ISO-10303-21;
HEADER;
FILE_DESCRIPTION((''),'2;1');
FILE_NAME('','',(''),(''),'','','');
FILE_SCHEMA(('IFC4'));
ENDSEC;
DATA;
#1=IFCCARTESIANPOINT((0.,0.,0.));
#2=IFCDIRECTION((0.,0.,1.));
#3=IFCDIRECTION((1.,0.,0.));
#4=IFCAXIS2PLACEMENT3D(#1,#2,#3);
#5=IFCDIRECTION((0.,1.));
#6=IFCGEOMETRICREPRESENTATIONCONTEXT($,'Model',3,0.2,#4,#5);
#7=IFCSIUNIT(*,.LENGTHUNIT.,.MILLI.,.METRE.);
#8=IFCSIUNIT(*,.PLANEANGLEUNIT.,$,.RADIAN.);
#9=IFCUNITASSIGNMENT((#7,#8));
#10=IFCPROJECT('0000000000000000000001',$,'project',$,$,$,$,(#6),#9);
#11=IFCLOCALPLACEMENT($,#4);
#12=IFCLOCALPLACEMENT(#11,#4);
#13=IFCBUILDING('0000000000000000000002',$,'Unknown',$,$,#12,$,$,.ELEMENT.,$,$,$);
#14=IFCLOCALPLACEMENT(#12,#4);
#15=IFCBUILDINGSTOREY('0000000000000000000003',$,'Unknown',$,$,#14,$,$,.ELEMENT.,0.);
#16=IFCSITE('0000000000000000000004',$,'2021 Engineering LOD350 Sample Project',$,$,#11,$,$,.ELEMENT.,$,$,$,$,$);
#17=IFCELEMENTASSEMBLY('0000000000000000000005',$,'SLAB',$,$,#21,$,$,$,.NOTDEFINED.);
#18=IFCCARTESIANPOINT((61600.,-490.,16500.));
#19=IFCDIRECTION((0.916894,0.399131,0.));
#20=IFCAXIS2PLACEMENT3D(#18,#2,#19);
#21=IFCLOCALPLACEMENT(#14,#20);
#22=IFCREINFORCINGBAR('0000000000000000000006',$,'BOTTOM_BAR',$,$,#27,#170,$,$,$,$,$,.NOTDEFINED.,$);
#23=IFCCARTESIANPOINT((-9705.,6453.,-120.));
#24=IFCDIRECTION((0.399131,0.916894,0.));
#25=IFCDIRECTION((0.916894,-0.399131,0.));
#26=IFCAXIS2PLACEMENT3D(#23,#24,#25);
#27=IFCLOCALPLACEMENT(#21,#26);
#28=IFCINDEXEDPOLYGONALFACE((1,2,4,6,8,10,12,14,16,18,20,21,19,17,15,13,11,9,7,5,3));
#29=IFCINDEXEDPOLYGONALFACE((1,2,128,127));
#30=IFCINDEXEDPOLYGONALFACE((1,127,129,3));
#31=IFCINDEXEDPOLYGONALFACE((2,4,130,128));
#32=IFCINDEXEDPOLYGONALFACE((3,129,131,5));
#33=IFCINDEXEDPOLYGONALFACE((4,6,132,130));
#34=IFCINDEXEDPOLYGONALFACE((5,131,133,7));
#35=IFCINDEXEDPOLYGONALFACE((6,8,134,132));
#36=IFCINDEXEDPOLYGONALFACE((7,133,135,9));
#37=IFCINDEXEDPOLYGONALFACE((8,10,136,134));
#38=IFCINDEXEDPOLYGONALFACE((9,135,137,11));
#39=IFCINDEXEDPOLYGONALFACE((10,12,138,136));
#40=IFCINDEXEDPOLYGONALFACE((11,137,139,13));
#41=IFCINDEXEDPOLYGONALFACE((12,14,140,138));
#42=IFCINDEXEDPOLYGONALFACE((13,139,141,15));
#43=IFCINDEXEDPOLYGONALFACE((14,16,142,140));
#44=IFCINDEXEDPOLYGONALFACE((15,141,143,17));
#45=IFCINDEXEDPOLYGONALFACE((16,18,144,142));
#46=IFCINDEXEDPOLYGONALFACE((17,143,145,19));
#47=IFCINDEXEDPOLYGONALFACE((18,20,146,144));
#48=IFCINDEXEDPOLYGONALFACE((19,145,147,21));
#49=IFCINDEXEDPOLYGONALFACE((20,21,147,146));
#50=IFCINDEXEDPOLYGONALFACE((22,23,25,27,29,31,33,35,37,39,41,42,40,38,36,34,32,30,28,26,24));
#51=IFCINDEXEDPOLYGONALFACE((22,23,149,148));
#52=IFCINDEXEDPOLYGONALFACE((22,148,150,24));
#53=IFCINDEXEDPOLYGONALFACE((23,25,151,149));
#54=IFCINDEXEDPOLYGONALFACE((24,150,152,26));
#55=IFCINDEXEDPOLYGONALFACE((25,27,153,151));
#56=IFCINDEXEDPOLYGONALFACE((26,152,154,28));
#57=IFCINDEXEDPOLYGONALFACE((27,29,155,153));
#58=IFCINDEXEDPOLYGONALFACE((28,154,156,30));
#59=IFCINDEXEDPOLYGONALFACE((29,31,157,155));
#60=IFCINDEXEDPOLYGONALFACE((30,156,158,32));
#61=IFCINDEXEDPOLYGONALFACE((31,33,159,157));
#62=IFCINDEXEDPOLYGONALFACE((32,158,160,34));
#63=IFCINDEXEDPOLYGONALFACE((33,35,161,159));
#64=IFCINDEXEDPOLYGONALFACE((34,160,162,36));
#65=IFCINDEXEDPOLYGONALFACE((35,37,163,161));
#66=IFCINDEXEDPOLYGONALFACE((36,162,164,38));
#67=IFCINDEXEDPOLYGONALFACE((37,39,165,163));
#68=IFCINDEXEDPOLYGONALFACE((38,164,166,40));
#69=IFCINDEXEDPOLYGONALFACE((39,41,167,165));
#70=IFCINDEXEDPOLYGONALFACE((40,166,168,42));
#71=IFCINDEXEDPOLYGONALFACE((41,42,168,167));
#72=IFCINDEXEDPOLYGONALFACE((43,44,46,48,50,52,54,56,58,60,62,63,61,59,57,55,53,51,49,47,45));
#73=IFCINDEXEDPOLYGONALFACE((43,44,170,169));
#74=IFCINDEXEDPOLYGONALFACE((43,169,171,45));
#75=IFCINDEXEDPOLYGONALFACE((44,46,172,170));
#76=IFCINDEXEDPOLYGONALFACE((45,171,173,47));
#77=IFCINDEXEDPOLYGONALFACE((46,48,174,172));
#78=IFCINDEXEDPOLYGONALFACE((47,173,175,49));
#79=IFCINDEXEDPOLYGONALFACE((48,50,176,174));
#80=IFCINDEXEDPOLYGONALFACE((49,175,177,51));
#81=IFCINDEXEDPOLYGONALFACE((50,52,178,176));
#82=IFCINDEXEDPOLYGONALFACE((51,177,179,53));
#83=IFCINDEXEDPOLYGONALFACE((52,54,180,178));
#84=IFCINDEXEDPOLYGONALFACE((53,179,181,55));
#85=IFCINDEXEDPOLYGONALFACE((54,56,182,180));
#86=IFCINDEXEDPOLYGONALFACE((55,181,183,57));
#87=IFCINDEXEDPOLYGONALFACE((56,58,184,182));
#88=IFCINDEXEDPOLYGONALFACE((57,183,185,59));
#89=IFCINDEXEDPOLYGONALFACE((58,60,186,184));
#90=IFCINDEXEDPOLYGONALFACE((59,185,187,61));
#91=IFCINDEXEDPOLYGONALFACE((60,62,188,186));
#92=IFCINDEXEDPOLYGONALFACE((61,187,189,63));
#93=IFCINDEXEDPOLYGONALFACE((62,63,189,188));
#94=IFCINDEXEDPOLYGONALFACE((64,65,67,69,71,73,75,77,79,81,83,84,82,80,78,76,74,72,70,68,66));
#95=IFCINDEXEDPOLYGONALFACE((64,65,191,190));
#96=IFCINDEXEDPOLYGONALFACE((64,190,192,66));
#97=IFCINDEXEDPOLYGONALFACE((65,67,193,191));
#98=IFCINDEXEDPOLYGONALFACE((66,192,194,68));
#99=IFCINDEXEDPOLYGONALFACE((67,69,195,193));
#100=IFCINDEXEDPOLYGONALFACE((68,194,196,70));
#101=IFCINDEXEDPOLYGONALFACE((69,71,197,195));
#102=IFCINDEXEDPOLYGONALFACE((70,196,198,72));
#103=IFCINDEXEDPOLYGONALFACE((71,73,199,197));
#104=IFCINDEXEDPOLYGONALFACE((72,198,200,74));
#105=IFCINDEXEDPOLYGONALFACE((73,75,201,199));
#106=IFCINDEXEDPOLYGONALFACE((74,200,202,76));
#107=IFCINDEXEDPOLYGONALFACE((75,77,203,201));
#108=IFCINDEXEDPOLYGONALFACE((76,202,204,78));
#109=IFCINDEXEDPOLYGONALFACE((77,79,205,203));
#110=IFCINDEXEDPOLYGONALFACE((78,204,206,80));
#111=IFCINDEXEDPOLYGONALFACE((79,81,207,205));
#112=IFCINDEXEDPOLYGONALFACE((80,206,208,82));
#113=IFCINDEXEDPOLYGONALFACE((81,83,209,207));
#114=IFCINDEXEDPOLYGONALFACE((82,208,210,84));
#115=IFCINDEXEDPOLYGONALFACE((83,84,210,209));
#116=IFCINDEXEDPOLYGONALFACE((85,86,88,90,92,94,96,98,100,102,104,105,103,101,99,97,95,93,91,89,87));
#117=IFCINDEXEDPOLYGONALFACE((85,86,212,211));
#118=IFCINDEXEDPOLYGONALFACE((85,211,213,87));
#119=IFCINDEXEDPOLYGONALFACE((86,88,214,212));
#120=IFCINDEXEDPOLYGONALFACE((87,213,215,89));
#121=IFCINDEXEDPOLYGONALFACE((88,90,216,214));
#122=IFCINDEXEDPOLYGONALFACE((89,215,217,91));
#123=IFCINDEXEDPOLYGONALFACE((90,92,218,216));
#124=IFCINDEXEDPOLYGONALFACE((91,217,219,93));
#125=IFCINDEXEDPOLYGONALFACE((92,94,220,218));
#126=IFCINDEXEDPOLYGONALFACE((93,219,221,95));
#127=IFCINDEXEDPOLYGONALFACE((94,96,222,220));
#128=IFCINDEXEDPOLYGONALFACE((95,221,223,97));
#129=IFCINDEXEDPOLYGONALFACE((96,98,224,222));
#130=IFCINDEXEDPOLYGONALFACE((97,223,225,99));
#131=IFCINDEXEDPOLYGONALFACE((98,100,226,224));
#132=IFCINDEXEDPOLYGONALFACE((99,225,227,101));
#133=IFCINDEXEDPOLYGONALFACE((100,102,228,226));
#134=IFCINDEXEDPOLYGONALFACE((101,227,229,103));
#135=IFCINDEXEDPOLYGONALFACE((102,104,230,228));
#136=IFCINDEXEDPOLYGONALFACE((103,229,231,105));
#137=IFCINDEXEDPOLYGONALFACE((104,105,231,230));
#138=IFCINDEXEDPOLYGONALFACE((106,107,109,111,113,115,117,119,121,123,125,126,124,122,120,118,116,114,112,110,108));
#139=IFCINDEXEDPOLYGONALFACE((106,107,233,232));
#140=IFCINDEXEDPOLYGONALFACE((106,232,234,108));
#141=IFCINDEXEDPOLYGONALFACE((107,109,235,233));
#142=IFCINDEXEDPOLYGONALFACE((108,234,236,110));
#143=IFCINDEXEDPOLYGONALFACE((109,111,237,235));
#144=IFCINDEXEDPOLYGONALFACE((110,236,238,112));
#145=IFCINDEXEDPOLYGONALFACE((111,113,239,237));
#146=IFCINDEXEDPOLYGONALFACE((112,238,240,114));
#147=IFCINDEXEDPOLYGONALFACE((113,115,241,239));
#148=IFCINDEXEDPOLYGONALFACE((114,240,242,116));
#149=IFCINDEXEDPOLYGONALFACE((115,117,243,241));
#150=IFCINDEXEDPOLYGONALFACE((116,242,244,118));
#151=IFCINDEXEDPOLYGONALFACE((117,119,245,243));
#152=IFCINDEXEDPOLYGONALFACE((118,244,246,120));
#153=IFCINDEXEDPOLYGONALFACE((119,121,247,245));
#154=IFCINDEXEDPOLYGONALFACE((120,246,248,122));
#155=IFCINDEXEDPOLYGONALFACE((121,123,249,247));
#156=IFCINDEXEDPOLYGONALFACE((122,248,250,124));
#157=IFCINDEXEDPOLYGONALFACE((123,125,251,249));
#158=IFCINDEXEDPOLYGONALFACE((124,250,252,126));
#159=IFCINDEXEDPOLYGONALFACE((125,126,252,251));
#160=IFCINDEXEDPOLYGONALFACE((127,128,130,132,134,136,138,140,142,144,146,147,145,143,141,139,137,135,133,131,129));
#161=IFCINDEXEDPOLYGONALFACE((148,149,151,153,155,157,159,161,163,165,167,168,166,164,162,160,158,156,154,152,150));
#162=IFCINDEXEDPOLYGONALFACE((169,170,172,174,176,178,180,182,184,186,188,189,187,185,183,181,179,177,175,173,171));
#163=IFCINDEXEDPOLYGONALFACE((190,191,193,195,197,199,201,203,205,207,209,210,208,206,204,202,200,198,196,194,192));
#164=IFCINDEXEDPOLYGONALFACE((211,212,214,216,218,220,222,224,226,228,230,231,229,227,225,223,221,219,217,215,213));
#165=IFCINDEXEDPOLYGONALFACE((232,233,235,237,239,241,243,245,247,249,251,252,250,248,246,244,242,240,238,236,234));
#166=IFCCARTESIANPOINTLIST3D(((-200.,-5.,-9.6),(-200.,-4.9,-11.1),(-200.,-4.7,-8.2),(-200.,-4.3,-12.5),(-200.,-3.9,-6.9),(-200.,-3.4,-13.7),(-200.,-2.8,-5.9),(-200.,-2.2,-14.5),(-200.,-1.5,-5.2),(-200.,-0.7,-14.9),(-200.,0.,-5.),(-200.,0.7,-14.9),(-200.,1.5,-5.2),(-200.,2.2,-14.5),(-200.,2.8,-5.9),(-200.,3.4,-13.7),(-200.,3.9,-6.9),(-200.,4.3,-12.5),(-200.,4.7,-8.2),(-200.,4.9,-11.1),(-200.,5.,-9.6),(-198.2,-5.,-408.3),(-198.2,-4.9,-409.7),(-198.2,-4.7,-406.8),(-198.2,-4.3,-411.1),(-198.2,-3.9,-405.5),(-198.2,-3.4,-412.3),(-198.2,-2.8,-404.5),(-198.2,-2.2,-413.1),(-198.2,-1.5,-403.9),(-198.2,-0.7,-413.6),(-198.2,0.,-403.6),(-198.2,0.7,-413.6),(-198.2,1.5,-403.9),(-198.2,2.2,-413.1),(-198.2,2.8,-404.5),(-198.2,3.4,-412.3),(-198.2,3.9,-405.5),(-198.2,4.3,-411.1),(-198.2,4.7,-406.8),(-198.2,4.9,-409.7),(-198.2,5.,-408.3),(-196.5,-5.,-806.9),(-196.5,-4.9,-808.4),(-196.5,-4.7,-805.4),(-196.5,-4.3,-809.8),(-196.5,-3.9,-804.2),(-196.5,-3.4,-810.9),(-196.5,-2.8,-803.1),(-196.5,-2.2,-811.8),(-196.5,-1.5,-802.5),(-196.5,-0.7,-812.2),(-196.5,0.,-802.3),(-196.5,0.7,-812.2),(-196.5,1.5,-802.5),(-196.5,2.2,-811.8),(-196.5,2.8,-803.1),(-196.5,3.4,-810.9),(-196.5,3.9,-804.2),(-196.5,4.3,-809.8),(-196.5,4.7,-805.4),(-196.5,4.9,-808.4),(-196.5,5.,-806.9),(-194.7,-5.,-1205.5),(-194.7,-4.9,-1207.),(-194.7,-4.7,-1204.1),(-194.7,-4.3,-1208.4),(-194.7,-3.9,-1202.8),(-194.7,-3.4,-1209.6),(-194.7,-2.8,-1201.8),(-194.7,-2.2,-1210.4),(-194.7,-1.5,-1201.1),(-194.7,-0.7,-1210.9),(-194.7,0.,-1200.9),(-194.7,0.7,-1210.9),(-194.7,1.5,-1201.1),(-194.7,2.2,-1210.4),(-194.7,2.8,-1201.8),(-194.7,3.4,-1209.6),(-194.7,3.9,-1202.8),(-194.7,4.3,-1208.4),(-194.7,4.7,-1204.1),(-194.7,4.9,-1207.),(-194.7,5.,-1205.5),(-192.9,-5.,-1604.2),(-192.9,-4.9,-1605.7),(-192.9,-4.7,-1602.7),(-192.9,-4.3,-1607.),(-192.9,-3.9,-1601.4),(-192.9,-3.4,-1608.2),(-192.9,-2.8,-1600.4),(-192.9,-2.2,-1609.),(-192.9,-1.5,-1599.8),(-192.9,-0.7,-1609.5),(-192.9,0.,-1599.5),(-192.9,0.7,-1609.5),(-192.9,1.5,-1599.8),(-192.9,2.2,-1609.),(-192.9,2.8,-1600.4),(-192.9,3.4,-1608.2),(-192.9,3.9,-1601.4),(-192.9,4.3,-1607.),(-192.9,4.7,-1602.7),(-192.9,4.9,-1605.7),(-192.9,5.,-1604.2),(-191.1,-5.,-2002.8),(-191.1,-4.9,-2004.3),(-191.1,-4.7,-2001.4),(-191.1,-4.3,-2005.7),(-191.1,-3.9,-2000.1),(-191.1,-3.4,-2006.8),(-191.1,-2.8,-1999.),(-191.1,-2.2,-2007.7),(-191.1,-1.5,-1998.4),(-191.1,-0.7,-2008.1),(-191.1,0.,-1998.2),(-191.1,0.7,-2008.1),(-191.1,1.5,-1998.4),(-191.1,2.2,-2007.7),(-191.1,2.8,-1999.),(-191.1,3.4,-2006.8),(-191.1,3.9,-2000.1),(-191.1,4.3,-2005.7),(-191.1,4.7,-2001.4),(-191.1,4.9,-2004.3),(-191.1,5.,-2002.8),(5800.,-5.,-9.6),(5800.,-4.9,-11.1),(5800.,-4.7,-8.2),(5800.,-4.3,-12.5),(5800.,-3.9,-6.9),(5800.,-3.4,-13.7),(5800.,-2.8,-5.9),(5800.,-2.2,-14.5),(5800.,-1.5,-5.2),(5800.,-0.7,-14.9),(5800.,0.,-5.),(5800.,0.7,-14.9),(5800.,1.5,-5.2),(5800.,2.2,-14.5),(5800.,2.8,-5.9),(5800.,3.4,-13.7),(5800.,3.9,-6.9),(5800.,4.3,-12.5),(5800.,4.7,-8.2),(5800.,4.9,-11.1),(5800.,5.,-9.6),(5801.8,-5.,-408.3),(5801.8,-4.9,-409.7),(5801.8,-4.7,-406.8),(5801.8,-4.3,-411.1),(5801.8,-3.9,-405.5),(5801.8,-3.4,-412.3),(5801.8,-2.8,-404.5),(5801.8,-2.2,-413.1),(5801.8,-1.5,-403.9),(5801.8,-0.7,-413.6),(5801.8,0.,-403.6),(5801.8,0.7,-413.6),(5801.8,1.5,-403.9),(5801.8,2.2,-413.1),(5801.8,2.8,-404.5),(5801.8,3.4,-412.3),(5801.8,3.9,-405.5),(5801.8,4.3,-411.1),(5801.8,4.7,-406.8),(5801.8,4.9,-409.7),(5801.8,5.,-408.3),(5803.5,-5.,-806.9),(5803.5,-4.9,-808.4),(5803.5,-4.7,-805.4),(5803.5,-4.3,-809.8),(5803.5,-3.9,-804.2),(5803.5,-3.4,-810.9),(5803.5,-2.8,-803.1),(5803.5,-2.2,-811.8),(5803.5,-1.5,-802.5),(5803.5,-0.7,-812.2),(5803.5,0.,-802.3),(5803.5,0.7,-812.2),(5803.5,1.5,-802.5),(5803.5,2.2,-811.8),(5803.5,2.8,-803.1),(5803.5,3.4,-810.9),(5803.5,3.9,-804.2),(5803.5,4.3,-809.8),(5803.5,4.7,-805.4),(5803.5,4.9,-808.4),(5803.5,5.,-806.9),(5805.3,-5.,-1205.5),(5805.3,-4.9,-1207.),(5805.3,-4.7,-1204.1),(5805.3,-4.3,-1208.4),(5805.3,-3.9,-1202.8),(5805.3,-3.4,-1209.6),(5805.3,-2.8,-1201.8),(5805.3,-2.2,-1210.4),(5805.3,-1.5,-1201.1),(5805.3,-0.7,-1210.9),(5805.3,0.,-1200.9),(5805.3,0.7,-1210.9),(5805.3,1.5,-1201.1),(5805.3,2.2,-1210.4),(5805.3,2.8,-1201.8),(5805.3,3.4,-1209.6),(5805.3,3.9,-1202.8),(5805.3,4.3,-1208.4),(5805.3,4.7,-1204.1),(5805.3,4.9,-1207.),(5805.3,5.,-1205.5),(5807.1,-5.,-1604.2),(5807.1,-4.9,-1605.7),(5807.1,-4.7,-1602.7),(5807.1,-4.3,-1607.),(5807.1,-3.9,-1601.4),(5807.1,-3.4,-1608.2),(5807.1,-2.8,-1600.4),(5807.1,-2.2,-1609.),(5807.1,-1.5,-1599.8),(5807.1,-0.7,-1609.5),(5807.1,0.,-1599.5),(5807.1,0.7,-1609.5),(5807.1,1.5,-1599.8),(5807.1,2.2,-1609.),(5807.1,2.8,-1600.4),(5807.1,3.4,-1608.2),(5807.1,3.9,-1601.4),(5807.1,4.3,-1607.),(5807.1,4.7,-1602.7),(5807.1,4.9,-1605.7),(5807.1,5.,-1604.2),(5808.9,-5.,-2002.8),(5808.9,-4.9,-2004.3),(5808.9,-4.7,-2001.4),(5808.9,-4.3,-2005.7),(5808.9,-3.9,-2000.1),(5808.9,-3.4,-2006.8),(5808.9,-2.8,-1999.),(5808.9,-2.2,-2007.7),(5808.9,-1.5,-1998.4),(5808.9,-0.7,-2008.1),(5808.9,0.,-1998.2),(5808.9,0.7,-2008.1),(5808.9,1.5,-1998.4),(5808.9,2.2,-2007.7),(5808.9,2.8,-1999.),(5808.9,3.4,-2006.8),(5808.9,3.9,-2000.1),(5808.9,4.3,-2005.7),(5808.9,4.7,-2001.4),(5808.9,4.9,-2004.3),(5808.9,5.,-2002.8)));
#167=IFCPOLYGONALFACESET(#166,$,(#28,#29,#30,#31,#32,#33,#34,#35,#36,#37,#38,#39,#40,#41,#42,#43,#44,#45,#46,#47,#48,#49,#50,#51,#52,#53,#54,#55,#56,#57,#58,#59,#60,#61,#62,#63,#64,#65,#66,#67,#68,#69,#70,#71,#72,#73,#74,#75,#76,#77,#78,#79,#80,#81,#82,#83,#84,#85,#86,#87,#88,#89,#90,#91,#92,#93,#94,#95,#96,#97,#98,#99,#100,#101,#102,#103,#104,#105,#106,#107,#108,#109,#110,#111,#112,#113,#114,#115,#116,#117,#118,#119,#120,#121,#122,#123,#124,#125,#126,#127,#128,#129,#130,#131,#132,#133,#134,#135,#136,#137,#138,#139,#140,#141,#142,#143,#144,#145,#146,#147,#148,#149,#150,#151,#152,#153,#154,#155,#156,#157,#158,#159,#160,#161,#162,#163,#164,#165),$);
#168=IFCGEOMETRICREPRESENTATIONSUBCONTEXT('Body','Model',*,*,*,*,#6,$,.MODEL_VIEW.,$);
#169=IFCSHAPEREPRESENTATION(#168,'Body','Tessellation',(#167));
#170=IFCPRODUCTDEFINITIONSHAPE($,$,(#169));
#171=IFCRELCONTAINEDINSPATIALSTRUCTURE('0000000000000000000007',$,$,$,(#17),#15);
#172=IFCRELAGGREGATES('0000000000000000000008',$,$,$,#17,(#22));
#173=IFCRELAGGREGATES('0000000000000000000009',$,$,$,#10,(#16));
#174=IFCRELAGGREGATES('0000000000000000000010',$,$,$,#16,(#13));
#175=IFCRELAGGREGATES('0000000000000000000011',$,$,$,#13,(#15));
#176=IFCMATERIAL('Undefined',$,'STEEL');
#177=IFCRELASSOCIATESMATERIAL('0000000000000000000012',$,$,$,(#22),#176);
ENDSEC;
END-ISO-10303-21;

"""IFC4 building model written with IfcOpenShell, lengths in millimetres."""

from ifc_helpers import new_model, entity, si_unit, direction, frame, origin_with_axes, place, context, subcontext, project, spatial, source, transform, mapped, material, element, aggregate, save


model = new_model("IFC4")

# Units and contexts
model_context = context("Model", 3, precision=0.2, world=origin_with_axes(), true_north=direction((0.0, 1.0)))
body_context = subcontext(model_context, "Body", "Model", "MODEL_VIEW")
ifc_project = project(units=[si_unit("LENGTHUNIT", "METRE", prefix="MILLI"), si_unit("PLANEANGLEUNIT", "RADIAN")], contexts=[model_context])

# Site, building, storey
site_placement = place(None, origin_with_axes())
site = spatial("IfcSite", under=ifc_project, at=site_placement, Name="2021 Engineering LOD350 Sample Project", CompositionType="ELEMENT")
building_placement = place(site_placement, origin_with_axes())
building = spatial("IfcBuilding", under=site, at=building_placement, Name="Unknown", CompositionType="ELEMENT")
storey_placement = place(building_placement, origin_with_axes())
storey = spatial("IfcBuildingStorey", under=building, at=storey_placement, Name="Unknown", CompositionType="ELEMENT", Elevation=0.0)

# Element assembly, reinforcing bar
assembly_1_placement = place(storey_placement, frame((61600.0, -490.0, 16500.0), z_axis=(0.0, 0.0, 1.0), x_axis=(0.916894, 0.399131, 0.0)))
assembly_1 = element("IfcElementAssembly", 1, at=assembly_1_placement, inside=storey, Name="SLAB", PredefinedType="NOTDEFINED")
ifc_material_1 = material(Name="Undefined", Category="STEEL")
shared_shape_1 = source(origin_with_axes(), body_context, "Body", "AdvancedSweptSolid", [
    entity("IfcSweptDiskSolid", entity("IfcIndexedPolyCurve", entity("IfcCartesianPointList3D", [[-200.0, 0.0, -10.0], [5800.0, 0.0, -10.0]]), [entity("IfcLineIndex", [1, 2])]), 5.0),
])
reinforcing_bar_1_placement = place(assembly_1_placement, frame((-9705.0, 6453.0, -120.0), z_axis=(0.399131, 0.916894, 0.0), x_axis=(0.916894, -0.399131, 0.0)))
reinforcing_bar_1 = element("IfcReinforcingBar", 2, at=reinforcing_bar_1_placement, material=ifc_material_1, Name="BOTTOM_BAR", PredefinedType="NOTDEFINED", context=body_context, shape_type="MappedRepresentation", body=[
    mapped(shared_shape_1, transform((0.0, 0.0, 0.0))),
    mapped(shared_shape_1, transform((1.8, 0.0, -398.6))),
    mapped(shared_shape_1, transform((3.5, 0.0, -797.3))),
    mapped(shared_shape_1, transform((5.3, 0.0, -1195.9))),
    mapped(shared_shape_1, transform((7.1, 0.0, -1594.5))),
    mapped(shared_shape_1, transform((8.9, 0.0, -1993.2))),
])

aggregate(assembly_1, [reinforcing_bar_1])

save(model, "model.ifc")
